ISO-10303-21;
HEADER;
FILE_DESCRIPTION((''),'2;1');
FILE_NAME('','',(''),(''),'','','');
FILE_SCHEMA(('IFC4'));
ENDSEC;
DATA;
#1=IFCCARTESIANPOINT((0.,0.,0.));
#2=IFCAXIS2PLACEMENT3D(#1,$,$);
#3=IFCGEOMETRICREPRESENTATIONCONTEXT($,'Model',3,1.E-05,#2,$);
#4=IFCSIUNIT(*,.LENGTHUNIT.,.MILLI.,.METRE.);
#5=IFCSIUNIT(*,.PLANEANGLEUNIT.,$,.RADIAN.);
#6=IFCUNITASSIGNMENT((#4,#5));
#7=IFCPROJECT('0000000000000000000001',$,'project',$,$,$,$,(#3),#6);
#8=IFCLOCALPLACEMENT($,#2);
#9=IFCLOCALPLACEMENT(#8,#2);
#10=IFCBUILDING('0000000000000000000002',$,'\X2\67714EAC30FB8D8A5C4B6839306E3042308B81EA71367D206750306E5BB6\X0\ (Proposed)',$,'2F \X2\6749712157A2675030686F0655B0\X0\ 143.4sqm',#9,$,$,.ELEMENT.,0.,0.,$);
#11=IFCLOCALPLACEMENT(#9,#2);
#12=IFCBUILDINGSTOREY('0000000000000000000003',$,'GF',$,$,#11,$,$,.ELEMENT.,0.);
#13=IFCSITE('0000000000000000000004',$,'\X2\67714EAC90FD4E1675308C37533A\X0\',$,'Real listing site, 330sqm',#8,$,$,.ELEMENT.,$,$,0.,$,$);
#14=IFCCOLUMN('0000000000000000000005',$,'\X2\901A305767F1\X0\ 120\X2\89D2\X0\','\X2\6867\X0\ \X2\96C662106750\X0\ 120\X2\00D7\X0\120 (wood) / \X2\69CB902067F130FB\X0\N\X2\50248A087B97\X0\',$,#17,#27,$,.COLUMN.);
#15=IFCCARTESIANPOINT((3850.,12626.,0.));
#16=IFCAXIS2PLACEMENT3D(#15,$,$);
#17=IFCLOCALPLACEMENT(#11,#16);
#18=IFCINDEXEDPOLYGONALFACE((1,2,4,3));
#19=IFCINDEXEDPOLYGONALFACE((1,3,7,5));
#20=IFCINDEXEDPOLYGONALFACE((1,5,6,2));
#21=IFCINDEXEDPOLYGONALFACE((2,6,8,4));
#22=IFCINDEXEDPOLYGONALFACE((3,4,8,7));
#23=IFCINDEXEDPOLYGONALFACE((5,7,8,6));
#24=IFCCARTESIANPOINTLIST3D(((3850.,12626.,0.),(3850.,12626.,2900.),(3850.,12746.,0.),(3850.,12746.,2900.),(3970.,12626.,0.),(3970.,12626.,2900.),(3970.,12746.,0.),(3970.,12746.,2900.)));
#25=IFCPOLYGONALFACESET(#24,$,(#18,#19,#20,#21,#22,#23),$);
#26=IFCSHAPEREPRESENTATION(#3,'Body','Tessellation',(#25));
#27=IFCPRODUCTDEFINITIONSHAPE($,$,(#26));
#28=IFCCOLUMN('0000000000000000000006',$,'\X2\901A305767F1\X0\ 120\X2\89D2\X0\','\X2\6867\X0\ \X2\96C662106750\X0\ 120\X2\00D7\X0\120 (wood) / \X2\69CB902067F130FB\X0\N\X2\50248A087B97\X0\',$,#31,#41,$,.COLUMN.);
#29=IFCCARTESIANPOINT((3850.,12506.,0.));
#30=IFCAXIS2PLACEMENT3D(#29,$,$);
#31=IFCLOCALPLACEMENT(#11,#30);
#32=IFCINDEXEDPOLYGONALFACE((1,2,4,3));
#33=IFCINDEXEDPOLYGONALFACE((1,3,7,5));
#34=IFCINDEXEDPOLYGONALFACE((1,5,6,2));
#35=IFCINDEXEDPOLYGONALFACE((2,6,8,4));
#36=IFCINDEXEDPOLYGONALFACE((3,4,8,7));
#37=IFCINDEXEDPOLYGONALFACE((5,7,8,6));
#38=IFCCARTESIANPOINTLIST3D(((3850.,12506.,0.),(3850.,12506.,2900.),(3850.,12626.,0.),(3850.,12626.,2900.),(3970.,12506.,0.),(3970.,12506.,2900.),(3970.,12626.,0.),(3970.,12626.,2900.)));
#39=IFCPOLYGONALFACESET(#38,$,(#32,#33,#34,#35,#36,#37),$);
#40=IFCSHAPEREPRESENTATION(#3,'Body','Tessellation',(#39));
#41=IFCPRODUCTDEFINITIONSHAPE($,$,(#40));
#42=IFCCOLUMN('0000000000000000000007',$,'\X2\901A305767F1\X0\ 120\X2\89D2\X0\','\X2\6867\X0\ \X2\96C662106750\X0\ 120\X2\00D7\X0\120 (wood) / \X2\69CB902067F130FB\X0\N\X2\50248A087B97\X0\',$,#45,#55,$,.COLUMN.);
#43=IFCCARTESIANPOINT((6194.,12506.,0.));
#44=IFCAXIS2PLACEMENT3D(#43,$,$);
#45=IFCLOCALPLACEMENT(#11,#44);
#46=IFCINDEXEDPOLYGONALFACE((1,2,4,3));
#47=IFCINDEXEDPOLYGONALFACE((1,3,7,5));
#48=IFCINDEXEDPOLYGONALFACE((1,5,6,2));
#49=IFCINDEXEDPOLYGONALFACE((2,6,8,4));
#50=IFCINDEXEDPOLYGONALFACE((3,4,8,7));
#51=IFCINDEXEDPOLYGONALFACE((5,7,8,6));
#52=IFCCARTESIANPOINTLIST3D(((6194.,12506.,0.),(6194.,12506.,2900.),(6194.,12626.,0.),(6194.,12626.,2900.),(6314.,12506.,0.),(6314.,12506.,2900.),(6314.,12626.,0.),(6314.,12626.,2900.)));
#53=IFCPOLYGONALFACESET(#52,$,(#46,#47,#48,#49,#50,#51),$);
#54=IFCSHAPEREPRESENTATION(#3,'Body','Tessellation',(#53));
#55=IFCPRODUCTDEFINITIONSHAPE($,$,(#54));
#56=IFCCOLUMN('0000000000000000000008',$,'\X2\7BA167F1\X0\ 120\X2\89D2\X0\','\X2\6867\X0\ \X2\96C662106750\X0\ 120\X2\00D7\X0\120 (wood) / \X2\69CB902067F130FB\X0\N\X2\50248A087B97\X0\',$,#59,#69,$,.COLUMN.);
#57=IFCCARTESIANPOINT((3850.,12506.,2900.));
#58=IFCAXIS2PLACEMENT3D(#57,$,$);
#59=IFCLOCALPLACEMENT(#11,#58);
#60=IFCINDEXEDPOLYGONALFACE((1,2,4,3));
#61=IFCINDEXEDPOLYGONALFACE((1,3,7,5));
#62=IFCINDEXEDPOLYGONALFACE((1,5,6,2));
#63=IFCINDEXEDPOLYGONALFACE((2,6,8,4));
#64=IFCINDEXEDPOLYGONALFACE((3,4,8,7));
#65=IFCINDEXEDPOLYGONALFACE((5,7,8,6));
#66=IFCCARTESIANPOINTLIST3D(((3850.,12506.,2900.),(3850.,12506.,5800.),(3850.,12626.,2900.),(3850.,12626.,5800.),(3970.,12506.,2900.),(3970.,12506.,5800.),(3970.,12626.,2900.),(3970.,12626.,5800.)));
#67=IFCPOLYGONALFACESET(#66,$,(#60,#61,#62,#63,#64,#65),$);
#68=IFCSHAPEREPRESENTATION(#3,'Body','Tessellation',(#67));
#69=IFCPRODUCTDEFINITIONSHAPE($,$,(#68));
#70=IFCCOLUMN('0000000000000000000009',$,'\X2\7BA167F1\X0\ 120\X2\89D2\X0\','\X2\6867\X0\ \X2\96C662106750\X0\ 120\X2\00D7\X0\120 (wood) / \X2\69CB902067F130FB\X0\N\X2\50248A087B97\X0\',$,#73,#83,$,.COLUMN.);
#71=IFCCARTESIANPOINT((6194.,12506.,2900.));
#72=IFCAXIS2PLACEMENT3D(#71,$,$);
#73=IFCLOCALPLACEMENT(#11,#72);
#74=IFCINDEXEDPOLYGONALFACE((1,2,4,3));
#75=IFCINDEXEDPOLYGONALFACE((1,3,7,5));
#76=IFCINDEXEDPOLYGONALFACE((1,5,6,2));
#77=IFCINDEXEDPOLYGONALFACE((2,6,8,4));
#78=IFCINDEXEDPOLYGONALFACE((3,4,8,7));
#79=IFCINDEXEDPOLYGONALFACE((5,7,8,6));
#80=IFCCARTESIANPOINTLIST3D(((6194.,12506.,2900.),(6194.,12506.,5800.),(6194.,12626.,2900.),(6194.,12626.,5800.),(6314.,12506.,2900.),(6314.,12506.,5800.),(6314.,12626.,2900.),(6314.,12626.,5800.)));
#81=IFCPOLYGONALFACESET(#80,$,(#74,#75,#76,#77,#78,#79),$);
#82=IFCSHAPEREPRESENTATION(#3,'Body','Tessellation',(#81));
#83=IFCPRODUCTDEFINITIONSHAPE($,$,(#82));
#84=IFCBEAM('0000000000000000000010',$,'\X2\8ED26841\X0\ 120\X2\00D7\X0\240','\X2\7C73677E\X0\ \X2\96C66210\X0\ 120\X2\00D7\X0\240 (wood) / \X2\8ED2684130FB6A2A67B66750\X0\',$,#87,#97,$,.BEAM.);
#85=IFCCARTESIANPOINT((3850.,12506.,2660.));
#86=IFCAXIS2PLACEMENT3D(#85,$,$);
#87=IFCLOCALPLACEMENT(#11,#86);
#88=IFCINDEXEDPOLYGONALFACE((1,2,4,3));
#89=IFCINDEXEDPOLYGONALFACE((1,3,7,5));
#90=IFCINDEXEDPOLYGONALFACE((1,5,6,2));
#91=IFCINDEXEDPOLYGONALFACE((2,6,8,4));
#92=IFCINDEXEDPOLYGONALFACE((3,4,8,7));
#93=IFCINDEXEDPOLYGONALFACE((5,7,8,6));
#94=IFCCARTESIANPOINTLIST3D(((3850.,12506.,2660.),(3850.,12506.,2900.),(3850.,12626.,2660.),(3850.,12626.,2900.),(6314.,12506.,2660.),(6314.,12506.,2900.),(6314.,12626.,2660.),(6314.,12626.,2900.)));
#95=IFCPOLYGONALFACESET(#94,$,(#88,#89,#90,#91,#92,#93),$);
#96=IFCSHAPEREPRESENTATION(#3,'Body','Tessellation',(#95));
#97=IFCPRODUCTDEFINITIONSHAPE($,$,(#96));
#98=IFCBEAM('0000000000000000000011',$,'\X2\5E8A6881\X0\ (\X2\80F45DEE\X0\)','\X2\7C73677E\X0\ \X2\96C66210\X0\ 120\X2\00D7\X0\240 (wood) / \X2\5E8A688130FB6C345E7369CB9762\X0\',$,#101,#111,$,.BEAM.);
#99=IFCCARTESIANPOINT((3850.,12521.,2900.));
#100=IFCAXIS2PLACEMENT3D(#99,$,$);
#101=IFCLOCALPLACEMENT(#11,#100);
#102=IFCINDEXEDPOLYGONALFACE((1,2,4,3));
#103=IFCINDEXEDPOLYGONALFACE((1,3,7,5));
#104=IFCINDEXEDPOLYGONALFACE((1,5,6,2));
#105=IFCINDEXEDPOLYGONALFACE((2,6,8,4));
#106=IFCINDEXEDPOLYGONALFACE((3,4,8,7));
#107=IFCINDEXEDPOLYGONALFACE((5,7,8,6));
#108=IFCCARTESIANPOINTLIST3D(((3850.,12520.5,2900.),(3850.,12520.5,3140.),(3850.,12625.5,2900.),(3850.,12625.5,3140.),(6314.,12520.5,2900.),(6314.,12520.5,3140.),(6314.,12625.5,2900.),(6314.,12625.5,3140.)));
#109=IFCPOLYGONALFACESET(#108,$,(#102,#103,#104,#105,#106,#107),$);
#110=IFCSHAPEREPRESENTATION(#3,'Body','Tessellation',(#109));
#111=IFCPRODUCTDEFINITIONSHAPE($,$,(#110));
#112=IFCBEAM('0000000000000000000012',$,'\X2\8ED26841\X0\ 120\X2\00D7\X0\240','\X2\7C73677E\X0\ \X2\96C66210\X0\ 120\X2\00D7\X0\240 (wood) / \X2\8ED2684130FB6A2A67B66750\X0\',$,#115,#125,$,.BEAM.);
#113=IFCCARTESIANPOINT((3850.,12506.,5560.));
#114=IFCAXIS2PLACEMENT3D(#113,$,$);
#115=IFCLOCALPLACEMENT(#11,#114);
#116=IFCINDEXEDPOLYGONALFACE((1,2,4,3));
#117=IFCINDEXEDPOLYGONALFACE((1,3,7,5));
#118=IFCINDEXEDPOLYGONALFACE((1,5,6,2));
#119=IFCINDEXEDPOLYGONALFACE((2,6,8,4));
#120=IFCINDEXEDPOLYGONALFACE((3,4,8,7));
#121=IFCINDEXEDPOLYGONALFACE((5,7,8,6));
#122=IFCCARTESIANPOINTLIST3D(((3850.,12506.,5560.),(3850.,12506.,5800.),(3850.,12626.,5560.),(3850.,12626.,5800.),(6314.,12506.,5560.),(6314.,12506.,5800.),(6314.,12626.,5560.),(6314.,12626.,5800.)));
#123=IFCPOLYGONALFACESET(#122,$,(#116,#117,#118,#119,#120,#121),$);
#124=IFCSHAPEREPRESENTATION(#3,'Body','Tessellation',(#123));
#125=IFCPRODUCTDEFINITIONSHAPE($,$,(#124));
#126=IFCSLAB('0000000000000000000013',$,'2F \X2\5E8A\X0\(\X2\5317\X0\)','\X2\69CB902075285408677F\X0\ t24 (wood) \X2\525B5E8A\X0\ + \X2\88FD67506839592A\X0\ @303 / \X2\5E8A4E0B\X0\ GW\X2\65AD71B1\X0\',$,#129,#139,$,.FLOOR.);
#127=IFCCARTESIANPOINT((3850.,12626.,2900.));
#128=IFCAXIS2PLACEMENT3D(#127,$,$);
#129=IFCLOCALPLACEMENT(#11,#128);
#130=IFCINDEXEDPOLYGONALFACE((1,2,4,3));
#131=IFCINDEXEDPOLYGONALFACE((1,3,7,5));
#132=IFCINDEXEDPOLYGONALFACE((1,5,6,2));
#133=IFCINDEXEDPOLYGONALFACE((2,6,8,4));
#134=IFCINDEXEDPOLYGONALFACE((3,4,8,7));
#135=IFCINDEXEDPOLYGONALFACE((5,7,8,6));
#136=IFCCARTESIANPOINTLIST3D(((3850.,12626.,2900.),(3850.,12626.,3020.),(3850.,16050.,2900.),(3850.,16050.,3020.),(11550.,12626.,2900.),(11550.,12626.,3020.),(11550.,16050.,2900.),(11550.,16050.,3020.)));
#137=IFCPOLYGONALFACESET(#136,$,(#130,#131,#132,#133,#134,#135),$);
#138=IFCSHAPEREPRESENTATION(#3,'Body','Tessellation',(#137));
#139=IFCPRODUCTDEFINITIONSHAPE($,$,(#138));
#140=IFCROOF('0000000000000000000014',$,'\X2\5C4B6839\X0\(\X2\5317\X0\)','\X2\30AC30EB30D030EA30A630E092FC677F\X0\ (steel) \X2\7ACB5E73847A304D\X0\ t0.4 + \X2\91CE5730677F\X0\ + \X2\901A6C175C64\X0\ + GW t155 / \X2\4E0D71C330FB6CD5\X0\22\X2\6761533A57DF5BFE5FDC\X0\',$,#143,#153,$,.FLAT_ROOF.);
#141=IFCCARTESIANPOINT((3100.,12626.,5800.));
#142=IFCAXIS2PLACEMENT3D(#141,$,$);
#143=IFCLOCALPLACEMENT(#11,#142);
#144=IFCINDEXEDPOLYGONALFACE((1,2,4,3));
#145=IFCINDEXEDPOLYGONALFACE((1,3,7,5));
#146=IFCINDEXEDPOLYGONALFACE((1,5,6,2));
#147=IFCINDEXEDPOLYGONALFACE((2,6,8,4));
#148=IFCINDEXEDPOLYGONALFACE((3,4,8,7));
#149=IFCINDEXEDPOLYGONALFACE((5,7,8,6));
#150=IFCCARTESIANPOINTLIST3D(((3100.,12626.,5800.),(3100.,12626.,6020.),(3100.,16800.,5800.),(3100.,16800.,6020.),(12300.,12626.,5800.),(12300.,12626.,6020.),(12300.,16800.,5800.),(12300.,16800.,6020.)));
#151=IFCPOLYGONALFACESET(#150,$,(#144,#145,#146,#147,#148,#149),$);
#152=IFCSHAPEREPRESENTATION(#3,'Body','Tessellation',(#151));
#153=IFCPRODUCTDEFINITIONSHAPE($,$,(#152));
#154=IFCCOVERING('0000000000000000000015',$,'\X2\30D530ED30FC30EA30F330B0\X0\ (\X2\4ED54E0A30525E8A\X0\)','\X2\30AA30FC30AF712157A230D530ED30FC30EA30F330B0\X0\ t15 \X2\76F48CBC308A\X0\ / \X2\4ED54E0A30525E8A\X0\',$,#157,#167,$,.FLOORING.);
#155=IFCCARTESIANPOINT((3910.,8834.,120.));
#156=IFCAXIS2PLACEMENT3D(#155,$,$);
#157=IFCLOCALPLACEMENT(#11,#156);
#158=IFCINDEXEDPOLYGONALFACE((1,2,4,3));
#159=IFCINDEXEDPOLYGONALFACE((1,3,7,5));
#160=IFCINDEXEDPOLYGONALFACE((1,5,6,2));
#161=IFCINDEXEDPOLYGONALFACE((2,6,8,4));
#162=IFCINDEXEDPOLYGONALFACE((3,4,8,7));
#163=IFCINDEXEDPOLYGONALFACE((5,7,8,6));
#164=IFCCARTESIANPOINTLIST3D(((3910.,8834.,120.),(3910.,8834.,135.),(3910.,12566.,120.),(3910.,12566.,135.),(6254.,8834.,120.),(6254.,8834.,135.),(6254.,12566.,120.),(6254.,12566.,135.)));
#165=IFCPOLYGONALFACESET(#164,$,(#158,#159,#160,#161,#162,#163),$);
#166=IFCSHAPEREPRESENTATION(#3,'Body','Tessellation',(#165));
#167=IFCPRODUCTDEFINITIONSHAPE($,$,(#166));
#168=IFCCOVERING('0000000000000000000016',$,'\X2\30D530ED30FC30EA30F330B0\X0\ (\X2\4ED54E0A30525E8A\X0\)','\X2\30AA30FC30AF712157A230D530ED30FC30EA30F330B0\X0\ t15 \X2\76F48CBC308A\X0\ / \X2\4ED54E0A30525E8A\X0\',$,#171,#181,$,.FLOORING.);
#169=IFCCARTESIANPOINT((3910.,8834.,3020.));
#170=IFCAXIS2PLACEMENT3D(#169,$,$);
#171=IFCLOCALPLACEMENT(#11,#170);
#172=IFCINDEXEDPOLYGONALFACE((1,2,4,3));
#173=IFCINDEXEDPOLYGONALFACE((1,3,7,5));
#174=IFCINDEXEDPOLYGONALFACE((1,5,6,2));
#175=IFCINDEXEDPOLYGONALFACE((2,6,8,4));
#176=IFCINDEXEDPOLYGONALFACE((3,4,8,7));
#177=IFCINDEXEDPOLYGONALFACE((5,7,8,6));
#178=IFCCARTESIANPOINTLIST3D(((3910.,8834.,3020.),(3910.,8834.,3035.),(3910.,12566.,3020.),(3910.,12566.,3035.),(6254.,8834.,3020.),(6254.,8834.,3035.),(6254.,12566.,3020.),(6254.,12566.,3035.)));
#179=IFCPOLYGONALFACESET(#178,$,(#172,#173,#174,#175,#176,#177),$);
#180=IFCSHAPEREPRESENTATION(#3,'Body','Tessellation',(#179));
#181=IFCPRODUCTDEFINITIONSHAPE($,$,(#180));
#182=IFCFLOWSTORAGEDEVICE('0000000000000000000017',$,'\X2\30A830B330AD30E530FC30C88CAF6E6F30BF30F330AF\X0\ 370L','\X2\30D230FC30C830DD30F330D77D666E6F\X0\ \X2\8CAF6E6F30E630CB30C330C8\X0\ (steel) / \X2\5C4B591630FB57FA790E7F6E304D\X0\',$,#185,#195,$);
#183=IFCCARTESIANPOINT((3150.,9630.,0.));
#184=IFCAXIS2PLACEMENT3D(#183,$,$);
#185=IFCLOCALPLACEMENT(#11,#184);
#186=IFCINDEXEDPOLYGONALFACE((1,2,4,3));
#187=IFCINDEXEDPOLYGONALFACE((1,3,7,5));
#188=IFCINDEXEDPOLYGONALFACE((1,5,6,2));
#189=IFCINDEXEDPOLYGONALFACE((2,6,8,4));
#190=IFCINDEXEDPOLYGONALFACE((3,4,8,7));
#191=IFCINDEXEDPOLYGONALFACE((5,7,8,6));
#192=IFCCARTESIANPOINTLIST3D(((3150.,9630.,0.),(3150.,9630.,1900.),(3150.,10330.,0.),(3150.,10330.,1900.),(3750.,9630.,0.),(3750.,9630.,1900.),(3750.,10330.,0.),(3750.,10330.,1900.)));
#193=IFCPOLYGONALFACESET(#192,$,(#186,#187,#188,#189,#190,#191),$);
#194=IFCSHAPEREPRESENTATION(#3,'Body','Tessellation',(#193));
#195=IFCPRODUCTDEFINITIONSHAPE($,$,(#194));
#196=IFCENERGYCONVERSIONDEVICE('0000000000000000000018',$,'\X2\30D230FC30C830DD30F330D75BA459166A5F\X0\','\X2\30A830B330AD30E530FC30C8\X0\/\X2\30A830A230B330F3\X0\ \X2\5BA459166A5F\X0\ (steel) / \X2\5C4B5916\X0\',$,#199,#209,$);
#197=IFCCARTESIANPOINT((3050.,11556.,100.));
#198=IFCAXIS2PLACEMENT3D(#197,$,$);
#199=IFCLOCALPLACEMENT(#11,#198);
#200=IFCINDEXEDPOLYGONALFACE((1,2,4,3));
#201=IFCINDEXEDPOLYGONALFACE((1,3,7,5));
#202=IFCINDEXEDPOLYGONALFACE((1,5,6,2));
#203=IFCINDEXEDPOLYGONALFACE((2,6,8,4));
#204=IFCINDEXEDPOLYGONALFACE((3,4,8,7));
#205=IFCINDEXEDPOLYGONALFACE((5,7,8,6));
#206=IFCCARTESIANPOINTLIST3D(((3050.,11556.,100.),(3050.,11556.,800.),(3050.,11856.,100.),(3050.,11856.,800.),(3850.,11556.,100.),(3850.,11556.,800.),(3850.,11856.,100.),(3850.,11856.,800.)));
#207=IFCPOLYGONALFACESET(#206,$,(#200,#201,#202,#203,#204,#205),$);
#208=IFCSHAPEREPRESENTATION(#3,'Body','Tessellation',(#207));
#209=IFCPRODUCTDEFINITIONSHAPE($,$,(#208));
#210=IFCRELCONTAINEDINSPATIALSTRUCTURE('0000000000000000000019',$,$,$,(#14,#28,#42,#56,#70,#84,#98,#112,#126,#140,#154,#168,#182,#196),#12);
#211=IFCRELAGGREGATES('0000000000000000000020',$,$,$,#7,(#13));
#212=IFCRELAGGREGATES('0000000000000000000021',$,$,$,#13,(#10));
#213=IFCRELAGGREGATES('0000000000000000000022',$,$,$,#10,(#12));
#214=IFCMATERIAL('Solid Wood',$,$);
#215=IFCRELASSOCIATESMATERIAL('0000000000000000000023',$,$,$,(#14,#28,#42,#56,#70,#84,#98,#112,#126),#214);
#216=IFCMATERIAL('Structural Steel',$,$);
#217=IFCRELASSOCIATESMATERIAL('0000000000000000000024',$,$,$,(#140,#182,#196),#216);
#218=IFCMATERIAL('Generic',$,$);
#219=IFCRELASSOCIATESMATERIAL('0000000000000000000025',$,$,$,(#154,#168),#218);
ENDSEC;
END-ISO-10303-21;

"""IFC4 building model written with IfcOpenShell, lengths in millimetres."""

from ifc_helpers import new_model, si_unit, frame, frame_2d, origin, place, context, project, spatial, rectangle, extrude, material, element, save


model = new_model("IFC4")

# Units and contexts
model_context = context("Model", 3, precision=1e-05, world=origin())
ifc_project = project(units=[si_unit("LENGTHUNIT", "METRE", prefix="MILLI"), si_unit("PLANEANGLEUNIT", "RADIAN")], contexts=[model_context])

# Site, building, storey
site_placement = place(None, origin())
site = spatial("IfcSite", under=ifc_project, at=site_placement, Name="東京都世田谷区", ObjectType="Real listing site, 330sqm", CompositionType="ELEMENT", RefElevation=0.0)
building_placement = place(site_placement, origin())
building = spatial("IfcBuilding", under=site, at=building_placement, Name="東京・越屋根のある自然素材の家 (Proposed)", ObjectType="2F 杉無垢材と漆喰 143.4sqm", CompositionType="ELEMENT", ElevationOfRefHeight=0.0, ElevationOfTerrain=0.0)
storey_placement = place(building_placement, origin())
storey = spatial("IfcBuildingStorey", under=building, at=storey_placement, Name="GF", CompositionType="ELEMENT", Elevation=0.0)

# Columns
ifc_material_1 = material(Name="Solid Wood")
column_1_placement = place(storey_placement, frame((3850.0, 12626.0, 0.0)))
element("IfcColumn", 1, at=column_1_placement, inside=storey, material=ifc_material_1, Name="通し柱 120角", Description="桧 集成材 120×120 (wood) / 構造柱・N値計算", PredefinedType="COLUMN", context=model_context, shape_type="SweptSolid", body=[
    extrude(rectangle(XDim=120.0, YDim=120.0, at=frame_2d((60.0, 60.0))), frame((3850.0, 12626.0, 0.0)), (0.0, 0.0, 1.0), 2900.0),
])
column_2_placement = place(storey_placement, frame((3850.0, 12506.0, 0.0)))
element("IfcColumn", 2, at=column_2_placement, inside=storey, material=ifc_material_1, Name="通し柱 120角", Description="桧 集成材 120×120 (wood) / 構造柱・N値計算", PredefinedType="COLUMN", context=model_context, shape_type="SweptSolid", body=[
    extrude(rectangle(XDim=120.0, YDim=120.0, at=frame_2d((60.0, 60.0))), frame((3850.0, 12506.0, 0.0)), (0.0, 0.0, 1.0), 2900.0),
])
column_3_placement = place(storey_placement, frame((6194.0, 12506.0, 0.0)))
element("IfcColumn", 3, at=column_3_placement, inside=storey, material=ifc_material_1, Name="通し柱 120角", Description="桧 集成材 120×120 (wood) / 構造柱・N値計算", PredefinedType="COLUMN", context=model_context, shape_type="SweptSolid", body=[
    extrude(rectangle(XDim=120.0, YDim=120.0, at=frame_2d((60.0, 60.0))), frame((6194.0, 12506.0, 0.0)), (0.0, 0.0, 1.0), 2900.0),
])
column_4_placement = place(storey_placement, frame((3850.0, 12506.0, 2900.0)))
element("IfcColumn", 4, at=column_4_placement, inside=storey, material=ifc_material_1, Name="管柱 120角", Description="桧 集成材 120×120 (wood) / 構造柱・N値計算", PredefinedType="COLUMN", context=model_context, shape_type="SweptSolid", body=[
    extrude(rectangle(XDim=120.0, YDim=120.0, at=frame_2d((60.0, 60.0))), frame((3850.0, 12506.0, 2900.0)), (0.0, 0.0, 1.0), 2900.0),
])
column_5_placement = place(storey_placement, frame((6194.0, 12506.0, 2900.0)))
element("IfcColumn", 5, at=column_5_placement, inside=storey, material=ifc_material_1, Name="管柱 120角", Description="桧 集成材 120×120 (wood) / 構造柱・N値計算", PredefinedType="COLUMN", context=model_context, shape_type="SweptSolid", body=[
    extrude(rectangle(XDim=120.0, YDim=120.0, at=frame_2d((60.0, 60.0))), frame((6194.0, 12506.0, 2900.0)), (0.0, 0.0, 1.0), 2900.0),
])

# Beams
beam_1_placement = place(storey_placement, frame((3850.0, 12506.0, 2660.0)))
element("IfcBeam", 6, at=beam_1_placement, inside=storey, material=ifc_material_1, Name="軒桁 120×240", Description="米松 集成 120×240 (wood) / 軒桁・横架材", PredefinedType="BEAM", context=model_context, shape_type="SweptSolid", body=[
    extrude(rectangle(XDim=2464.0, YDim=120.0, at=frame_2d((1232.0, 60.0))), frame((3850.0, 12506.0, 2660.0)), (0.0, 0.0, 1.0), 240.0),
])
beam_2_placement = place(storey_placement, frame((3850.0, 12521.0, 2900.0)))
element("IfcBeam", 7, at=beam_2_placement, inside=storey, material=ifc_material_1, Name="床梁 (胴差)", Description="米松 集成 120×240 (wood) / 床梁・水平構面", PredefinedType="BEAM", context=model_context, shape_type="SweptSolid", body=[
    extrude(rectangle(XDim=2464.0, YDim=105.0, at=frame_2d((1232.0, 52.0))), frame((3850.0, 12521.0, 2900.0)), (0.0, 0.0, 1.0), 240.0),
])
beam_3_placement = place(storey_placement, frame((3850.0, 12506.0, 5560.0)))
element("IfcBeam", 8, at=beam_3_placement, inside=storey, material=ifc_material_1, Name="軒桁 120×240", Description="米松 集成 120×240 (wood) / 軒桁・横架材", PredefinedType="BEAM", context=model_context, shape_type="SweptSolid", body=[
    extrude(rectangle(XDim=2464.0, YDim=120.0, at=frame_2d((1232.0, 60.0))), frame((3850.0, 12506.0, 5560.0)), (0.0, 0.0, 1.0), 240.0),
])

# Slab
slab_1_placement = place(storey_placement, frame((3850.0, 12626.0, 2900.0)))
element("IfcSlab", 9, at=slab_1_placement, inside=storey, material=ifc_material_1, Name="2F 床(北)", Description="構造用合板 t24 (wood) 剛床 + 製材根太 @303 / 床下 GW断熱", PredefinedType="FLOOR", context=model_context, shape_type="SweptSolid", body=[
    extrude(rectangle(XDim=7700.0, YDim=3424.0, at=frame_2d((3850.0, 1712.0))), frame((3850.0, 12626.0, 2900.0)), (0.0, 0.0, 1.0), 120.0),
])

# Roof
ifc_material_2 = material(Name="Structural Steel")
for number, where, name in (
    (10, (3100.0, 12626.0, 5800.0), "屋根(北)"),
):
    element("IfcRoof", number, at=place(storey_placement, frame(where)), inside=storey, material=ifc_material_2, Name=name, Description="ガルバリウム鋼板 (steel) 立平葺き t0.4 + 野地板 + 通気層 + GW t155 / 不燃・法22条区域対応", PredefinedType="FLAT_ROOF", context=model_context, shape_type="SweptSolid", body=[
        extrude(rectangle(XDim=9200.0, YDim=4174.0, at=frame_2d((4600.0, 2087.0))), frame((3100.0, 12626.0, 5800.0)), (0.0, 0.0, 1.0), 220.0),
    ])

# Coverings
ifc_material_3 = material(Name="Generic")
covering_1_placement = place(storey_placement, frame((3910.0, 8834.0, 120.0)))
element("IfcCovering", 11, at=covering_1_placement, inside=storey, material=ifc_material_3, Name="フローリング (仕上げ床)", Description="オーク無垢フローリング t15 直貼り / 仕上げ床", PredefinedType="FLOORING", context=model_context, shape_type="SweptSolid", body=[
    extrude(rectangle(XDim=2344.0, YDim=3732.0, at=frame_2d((1172.0, 1866.0))), frame((3910.0, 8834.0, 120.0)), (0.0, 0.0, 1.0), 15.0),
])
covering_2_placement = place(storey_placement, frame((3910.0, 8834.0, 3020.0)))
element("IfcCovering", 12, at=covering_2_placement, inside=storey, material=ifc_material_3, Name="フローリング (仕上げ床)", Description="オーク無垢フローリング t15 直貼り / 仕上げ床", PredefinedType="FLOORING", context=model_context, shape_type="SweptSolid", body=[
    extrude(rectangle(XDim=2344.0, YDim=3732.0, at=frame_2d((1172.0, 1866.0))), frame((3910.0, 8834.0, 3020.0)), (0.0, 0.0, 1.0), 15.0),
])

# Flow storage device
flow_storage_device_placement = place(storey_placement, frame((3150.0, 9630.0, 0.0)))
element("IfcFlowStorageDevice", 13, at=flow_storage_device_placement, inside=storey, material=ifc_material_2, Name="エコキュート貯湯タンク 370L", Description="ヒートポンプ給湯 貯湯ユニット (steel) / 屋外・基礎置き", context=model_context, shape_type="SweptSolid", body=[
    extrude(rectangle(XDim=600.0, YDim=700.0, at=frame_2d((300.0, 350.0))), frame((3150.0, 9630.0, 0.0)), (0.0, 0.0, 1.0), 1900.0),
])

# Energy conversion device
energy_conversion_device_placement = place(storey_placement, frame((3050.0, 11556.0, 100.0)))
element("IfcEnergyConversionDevice", 14, at=energy_conversion_device_placement, inside=storey, material=ifc_material_2, Name="ヒートポンプ室外機", Description="エコキュート/エアコン 室外機 (steel) / 屋外", context=model_context, shape_type="SweptSolid", body=[
    extrude(rectangle(XDim=800.0, YDim=300.0, at=frame_2d((400.0, 150.0))), frame((3050.0, 11556.0, 100.0)), (0.0, 0.0, 1.0), 700.0),
])

save(model, "model.ifc")
